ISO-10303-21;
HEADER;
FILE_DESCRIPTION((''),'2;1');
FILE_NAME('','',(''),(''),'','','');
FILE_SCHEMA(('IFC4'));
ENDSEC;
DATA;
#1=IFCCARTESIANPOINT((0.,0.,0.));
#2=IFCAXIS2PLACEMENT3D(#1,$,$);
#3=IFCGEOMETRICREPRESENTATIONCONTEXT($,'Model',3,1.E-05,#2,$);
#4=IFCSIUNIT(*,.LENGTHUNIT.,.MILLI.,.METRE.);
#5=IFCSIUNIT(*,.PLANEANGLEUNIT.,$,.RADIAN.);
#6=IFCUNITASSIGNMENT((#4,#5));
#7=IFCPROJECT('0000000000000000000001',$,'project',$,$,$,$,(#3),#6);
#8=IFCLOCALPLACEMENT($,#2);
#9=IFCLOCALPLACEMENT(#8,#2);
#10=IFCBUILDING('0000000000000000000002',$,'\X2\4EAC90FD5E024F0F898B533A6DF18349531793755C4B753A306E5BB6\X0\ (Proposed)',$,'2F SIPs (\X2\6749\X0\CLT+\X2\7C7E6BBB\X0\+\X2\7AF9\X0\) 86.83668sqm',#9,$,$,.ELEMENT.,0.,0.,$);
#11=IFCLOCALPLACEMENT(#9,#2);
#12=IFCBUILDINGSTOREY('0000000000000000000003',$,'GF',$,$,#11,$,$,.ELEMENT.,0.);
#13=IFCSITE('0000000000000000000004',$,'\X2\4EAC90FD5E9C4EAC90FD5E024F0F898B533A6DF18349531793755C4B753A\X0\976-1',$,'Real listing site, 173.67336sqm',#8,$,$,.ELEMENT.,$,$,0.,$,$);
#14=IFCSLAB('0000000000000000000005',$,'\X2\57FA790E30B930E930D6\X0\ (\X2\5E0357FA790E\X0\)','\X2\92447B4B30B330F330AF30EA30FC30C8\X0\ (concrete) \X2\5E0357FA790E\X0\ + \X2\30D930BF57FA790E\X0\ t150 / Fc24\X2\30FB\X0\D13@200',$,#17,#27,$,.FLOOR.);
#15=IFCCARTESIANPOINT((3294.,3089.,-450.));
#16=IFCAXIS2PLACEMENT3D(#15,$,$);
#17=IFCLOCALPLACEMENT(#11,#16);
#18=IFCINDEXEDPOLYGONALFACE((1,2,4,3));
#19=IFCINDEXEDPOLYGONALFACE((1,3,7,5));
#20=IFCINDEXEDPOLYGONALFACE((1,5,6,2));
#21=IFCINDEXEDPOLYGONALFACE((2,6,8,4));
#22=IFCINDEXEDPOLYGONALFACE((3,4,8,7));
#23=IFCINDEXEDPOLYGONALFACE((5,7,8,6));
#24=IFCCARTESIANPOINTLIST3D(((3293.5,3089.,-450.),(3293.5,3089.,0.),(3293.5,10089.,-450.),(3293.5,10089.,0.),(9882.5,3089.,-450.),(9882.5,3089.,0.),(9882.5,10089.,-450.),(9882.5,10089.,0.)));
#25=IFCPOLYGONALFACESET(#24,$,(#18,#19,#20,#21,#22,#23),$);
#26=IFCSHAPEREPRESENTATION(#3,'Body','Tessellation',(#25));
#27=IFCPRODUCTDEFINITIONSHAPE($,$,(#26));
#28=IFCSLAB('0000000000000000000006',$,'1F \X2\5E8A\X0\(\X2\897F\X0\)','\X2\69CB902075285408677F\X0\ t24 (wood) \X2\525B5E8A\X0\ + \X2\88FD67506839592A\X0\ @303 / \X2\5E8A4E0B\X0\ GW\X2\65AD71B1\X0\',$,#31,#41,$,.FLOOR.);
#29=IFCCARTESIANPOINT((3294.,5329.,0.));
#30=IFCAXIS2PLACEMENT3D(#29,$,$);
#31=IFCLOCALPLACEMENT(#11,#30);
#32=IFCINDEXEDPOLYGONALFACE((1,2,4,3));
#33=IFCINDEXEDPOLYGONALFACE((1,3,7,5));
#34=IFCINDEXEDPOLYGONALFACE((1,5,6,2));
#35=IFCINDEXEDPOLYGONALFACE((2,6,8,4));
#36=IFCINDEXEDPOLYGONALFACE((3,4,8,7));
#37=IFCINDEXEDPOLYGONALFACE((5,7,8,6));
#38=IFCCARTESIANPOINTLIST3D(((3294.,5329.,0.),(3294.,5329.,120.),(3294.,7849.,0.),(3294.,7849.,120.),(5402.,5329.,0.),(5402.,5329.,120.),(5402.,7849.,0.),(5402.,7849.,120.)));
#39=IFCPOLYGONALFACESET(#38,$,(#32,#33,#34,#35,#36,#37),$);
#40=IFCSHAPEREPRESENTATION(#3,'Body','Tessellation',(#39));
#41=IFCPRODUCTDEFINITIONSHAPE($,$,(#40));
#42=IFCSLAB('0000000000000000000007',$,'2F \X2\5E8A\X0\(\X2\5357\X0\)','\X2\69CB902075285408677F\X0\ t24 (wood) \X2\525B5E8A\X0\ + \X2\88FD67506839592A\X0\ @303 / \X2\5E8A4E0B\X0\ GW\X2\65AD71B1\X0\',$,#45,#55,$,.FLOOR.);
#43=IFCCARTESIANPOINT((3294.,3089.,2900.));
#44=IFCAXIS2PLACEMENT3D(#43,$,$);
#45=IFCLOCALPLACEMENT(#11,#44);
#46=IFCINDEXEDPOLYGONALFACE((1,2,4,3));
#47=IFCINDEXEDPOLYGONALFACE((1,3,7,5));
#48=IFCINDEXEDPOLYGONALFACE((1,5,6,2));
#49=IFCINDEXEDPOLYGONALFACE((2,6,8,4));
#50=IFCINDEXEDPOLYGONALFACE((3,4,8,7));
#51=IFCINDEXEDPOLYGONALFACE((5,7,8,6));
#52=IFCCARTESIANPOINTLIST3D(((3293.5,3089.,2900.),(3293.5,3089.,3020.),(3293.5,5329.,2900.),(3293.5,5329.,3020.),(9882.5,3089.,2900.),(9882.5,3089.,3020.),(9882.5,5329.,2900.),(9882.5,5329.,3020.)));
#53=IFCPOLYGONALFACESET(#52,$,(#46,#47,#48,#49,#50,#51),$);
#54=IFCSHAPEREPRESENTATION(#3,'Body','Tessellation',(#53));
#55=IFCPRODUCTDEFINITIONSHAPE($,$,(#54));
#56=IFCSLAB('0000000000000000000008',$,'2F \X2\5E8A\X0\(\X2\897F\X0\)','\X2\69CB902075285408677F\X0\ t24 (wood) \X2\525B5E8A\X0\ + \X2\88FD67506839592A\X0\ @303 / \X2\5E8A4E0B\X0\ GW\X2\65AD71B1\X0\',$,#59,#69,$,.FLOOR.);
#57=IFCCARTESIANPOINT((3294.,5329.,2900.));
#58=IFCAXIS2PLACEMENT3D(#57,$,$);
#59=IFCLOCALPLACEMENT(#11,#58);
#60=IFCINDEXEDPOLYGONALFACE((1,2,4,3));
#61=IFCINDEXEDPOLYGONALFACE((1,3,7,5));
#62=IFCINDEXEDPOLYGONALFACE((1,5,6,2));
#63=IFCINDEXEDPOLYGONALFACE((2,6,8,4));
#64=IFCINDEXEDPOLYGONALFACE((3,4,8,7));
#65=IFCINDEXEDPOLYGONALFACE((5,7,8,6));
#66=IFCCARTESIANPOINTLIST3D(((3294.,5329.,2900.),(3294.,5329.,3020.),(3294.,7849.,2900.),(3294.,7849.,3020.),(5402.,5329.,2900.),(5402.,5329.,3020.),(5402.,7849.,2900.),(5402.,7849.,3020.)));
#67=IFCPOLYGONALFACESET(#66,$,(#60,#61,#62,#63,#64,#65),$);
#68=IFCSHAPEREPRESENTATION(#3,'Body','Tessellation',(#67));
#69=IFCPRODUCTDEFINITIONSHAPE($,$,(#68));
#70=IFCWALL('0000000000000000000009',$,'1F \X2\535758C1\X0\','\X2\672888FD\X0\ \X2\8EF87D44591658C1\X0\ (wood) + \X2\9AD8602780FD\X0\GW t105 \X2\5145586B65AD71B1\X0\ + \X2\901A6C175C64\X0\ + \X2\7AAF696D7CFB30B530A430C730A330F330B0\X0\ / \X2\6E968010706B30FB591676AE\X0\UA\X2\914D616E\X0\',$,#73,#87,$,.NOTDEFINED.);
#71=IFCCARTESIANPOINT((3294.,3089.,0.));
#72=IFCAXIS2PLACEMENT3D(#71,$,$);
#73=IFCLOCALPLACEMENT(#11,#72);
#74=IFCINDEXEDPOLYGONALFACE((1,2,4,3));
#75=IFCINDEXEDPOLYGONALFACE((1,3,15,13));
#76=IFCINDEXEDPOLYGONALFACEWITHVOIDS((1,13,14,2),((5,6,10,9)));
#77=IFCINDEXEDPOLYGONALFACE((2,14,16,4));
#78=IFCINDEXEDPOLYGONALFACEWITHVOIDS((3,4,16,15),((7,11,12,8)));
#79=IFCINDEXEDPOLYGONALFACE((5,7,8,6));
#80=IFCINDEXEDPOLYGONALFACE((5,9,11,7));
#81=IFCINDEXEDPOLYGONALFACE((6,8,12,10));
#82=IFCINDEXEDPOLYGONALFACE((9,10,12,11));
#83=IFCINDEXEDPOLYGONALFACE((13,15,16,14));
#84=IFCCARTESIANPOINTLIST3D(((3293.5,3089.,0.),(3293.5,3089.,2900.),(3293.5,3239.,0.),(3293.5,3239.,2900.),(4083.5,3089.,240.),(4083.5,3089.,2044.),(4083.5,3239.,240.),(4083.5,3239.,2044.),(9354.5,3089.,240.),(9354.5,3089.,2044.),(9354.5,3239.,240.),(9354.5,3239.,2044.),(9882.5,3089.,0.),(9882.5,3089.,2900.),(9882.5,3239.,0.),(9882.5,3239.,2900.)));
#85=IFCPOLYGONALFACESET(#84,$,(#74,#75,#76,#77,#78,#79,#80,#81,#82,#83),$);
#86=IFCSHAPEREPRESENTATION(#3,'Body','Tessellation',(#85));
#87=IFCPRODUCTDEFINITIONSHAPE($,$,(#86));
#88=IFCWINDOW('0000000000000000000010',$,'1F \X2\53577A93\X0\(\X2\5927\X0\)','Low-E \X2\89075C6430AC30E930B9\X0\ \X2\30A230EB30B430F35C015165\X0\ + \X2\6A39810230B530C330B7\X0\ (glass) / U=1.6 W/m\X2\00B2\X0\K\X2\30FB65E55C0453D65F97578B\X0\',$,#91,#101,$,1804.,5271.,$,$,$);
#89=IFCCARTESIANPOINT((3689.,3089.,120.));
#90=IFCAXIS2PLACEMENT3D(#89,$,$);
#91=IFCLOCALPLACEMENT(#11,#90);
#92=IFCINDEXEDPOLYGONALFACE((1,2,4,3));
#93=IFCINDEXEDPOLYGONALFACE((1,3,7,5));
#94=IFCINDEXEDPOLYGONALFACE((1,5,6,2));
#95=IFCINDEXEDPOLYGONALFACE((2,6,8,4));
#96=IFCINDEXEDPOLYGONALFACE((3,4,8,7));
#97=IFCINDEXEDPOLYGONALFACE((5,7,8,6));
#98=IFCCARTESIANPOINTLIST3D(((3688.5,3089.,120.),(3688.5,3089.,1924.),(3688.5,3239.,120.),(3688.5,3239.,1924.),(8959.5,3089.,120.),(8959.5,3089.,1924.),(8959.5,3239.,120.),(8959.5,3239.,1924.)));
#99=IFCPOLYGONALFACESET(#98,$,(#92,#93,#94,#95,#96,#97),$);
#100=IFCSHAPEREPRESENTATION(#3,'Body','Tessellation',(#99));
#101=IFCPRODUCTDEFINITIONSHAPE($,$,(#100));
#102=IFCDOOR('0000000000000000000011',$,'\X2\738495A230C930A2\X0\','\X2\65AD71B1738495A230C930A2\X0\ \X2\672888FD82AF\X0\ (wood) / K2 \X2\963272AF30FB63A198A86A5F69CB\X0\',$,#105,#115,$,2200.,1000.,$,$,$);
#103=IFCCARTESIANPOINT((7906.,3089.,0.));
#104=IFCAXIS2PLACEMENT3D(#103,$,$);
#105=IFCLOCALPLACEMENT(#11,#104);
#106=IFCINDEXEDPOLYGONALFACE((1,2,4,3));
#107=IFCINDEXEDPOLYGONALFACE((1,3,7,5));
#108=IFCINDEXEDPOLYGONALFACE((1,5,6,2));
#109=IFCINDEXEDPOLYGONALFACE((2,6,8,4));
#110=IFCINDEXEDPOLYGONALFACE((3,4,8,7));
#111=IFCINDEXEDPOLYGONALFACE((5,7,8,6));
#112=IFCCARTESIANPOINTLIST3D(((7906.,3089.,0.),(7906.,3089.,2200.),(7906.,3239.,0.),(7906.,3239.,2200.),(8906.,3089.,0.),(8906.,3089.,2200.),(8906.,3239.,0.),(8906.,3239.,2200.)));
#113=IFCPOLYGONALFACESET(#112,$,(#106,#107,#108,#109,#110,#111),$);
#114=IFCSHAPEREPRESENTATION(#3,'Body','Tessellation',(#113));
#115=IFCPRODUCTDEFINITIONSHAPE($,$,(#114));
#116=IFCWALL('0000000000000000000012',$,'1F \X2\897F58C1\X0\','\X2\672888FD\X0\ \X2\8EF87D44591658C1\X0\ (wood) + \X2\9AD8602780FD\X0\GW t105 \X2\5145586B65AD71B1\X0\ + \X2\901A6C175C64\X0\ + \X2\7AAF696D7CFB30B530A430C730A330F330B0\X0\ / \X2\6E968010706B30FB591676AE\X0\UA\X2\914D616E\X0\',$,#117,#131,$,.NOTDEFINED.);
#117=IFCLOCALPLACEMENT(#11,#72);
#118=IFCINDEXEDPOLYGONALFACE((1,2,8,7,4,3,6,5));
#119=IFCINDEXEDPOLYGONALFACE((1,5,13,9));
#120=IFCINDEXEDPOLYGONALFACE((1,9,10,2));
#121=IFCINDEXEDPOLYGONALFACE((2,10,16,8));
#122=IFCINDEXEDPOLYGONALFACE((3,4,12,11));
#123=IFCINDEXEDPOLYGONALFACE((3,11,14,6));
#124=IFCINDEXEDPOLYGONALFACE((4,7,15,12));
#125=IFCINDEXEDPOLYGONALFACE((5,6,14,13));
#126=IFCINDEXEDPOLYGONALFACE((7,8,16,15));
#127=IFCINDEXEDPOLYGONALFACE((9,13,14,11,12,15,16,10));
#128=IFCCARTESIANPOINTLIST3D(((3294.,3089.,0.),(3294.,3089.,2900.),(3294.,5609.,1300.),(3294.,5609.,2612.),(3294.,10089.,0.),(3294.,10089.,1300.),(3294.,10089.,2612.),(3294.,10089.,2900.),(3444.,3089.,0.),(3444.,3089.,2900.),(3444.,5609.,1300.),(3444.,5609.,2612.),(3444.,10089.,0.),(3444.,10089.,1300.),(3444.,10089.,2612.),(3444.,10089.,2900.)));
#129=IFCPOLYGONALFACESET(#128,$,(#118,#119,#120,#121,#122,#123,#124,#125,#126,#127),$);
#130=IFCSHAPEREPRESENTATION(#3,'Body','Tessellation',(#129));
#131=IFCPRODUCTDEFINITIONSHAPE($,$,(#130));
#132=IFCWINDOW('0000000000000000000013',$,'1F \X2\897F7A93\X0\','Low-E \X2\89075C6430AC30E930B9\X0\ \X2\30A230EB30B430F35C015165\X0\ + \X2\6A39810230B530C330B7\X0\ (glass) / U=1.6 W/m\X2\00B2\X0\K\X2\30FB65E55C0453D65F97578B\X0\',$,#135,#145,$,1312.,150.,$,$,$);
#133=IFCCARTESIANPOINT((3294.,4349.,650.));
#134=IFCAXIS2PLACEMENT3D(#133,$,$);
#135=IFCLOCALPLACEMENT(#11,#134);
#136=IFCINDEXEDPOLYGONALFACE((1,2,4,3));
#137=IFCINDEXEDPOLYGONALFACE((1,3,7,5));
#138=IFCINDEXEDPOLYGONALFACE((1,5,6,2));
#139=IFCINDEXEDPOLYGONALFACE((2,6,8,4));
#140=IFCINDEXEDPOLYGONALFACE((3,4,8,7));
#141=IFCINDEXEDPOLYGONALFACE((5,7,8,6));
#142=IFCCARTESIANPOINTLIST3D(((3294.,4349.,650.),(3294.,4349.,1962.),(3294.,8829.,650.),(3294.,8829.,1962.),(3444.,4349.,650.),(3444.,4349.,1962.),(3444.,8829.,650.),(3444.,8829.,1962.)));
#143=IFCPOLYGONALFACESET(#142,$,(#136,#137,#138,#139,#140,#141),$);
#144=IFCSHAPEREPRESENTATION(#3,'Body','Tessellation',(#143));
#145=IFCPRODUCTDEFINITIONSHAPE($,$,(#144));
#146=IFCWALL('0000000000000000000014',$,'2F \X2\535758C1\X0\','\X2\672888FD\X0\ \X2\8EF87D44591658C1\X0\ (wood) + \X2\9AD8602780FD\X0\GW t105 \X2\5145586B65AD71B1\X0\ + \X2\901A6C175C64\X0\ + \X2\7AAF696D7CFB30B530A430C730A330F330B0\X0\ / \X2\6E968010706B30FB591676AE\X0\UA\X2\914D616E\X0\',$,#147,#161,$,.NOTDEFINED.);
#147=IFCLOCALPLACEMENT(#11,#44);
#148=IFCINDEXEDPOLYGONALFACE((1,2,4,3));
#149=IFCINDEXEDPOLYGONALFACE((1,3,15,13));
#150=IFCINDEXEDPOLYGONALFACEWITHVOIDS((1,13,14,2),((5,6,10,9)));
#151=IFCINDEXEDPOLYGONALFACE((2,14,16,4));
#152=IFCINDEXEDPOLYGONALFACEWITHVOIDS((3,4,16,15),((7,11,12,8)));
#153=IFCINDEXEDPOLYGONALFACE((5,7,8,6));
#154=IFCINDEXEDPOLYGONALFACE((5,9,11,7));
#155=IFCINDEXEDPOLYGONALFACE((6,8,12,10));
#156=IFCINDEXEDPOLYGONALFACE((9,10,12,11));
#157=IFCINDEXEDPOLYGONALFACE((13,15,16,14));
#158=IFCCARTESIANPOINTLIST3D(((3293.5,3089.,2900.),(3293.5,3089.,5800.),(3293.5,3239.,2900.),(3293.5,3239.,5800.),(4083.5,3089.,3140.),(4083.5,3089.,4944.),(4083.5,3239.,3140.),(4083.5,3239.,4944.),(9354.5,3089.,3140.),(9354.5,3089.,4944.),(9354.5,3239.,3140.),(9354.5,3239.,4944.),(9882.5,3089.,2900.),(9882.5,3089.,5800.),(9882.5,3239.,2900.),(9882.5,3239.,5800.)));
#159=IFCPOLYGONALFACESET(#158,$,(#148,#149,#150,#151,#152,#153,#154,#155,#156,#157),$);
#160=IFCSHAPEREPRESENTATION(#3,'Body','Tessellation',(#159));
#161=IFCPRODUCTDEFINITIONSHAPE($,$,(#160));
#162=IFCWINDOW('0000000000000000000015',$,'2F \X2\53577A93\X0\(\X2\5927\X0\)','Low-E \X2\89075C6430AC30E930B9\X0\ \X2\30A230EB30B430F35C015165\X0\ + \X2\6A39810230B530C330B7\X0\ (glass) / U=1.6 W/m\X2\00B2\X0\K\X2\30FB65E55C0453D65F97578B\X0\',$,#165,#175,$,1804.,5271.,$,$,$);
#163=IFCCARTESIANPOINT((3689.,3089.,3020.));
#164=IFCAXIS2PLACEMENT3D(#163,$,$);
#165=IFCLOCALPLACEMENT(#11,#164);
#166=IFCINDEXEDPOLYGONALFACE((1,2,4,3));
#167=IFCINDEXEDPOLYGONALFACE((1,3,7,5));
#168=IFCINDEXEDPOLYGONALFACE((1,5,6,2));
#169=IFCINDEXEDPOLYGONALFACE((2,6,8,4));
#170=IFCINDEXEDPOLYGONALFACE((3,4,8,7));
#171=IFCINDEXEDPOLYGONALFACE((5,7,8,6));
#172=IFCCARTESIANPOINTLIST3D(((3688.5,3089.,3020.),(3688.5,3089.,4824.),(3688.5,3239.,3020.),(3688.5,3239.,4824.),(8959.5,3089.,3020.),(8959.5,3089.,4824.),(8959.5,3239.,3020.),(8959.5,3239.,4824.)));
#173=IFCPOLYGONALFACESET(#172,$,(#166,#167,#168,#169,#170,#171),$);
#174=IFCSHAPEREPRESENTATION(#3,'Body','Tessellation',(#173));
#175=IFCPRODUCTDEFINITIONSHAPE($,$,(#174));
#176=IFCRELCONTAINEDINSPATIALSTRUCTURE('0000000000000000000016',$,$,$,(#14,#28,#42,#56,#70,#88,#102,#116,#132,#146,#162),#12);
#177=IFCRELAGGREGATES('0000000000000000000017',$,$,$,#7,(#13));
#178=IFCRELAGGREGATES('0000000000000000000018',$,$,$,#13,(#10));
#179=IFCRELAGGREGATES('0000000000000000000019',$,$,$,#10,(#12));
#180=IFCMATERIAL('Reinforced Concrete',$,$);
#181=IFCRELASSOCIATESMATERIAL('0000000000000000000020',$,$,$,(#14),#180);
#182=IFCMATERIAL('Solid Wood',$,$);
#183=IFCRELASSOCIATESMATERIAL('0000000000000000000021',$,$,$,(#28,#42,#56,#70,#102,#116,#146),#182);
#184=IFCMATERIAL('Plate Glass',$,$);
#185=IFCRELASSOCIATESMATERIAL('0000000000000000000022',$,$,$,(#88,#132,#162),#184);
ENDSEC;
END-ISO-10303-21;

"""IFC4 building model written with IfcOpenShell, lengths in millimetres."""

from ifc_helpers import new_model, si_unit, frame, frame_2d, origin, place, context, project, spatial, rectangle, extrude, material, element, fill, save


model = new_model("IFC4")

# Units and contexts
model_context = context("Model", 3, precision=1e-05, world=origin())
ifc_project = project(units=[si_unit("LENGTHUNIT", "METRE", prefix="MILLI"), si_unit("PLANEANGLEUNIT", "RADIAN")], contexts=[model_context])

# Site, building, storey
site_placement = place(None, origin())
site = spatial("IfcSite", under=ifc_project, at=site_placement, Name="京都府京都市伏見区深草北鍵屋町976-1", ObjectType="Real listing site, 173.67336sqm", CompositionType="ELEMENT", RefElevation=0.0)
building_placement = place(site_placement, origin())
building = spatial("IfcBuilding", under=site, at=building_placement, Name="京都市伏見区深草北鍵屋町の家 (Proposed)", ObjectType="2F SIPs (杉CLT+籾殻+竹) 86.83668sqm", CompositionType="ELEMENT", ElevationOfRefHeight=0.0, ElevationOfTerrain=0.0)
storey_placement = place(building_placement, origin())
storey = spatial("IfcBuildingStorey", under=building, at=storey_placement, Name="GF", CompositionType="ELEMENT", Elevation=0.0)

# Slabs
ifc_material_1 = material(Name="Reinforced Concrete")
slab_1_placement = place(storey_placement, frame((3294.0, 3089.0, -450.0)))
element("IfcSlab", 1, at=slab_1_placement, inside=storey, material=ifc_material_1, Name="基礎スラブ (布基礎)", Description="鉄筋コンクリート (concrete) 布基礎 + ベタ基礎 t150 / Fc24・D13@200", PredefinedType="FLOOR", context=model_context, shape_type="SweptSolid", body=[
    extrude(rectangle(XDim=6589.0, YDim=7000.0, at=frame_2d((3294.0, 3500.0))), frame((3294.0, 3089.0, -450.0)), (0.0, 0.0, 1.0), 450.0),
])
ifc_material_2 = material(Name="Solid Wood")
slab_2_placement = place(storey_placement, frame((3294.0, 5329.0, 0.0)))
element("IfcSlab", 2, at=slab_2_placement, inside=storey, material=ifc_material_2, Name="1F 床(西)", Description="構造用合板 t24 (wood) 剛床 + 製材根太 @303 / 床下 GW断熱", PredefinedType="FLOOR", context=model_context, shape_type="SweptSolid", body=[
    extrude(rectangle(XDim=2108.0, YDim=2520.0, at=frame_2d((1054.0, 1260.0))), frame((3294.0, 5329.0, 0.0)), (0.0, 0.0, 1.0), 120.0),
])
slab_3_placement = place(storey_placement, frame((3294.0, 3089.0, 2900.0)))
element("IfcSlab", 3, at=slab_3_placement, inside=storey, material=ifc_material_2, Name="2F 床(南)", Description="構造用合板 t24 (wood) 剛床 + 製材根太 @303 / 床下 GW断熱", PredefinedType="FLOOR", context=model_context, shape_type="SweptSolid", body=[
    extrude(rectangle(XDim=6589.0, YDim=2240.0, at=frame_2d((3294.0, 1120.0))), frame((3294.0, 3089.0, 2900.0)), (0.0, 0.0, 1.0), 120.0),
])
slab_4_placement = place(storey_placement, frame((3294.0, 5329.0, 2900.0)))
element("IfcSlab", 4, at=slab_4_placement, inside=storey, material=ifc_material_2, Name="2F 床(西)", Description="構造用合板 t24 (wood) 剛床 + 製材根太 @303 / 床下 GW断熱", PredefinedType="FLOOR", context=model_context, shape_type="SweptSolid", body=[
    extrude(rectangle(XDim=2108.0, YDim=2520.0, at=frame_2d((1054.0, 1260.0))), frame((3294.0, 5329.0, 2900.0)), (0.0, 0.0, 1.0), 120.0),
])

# Wall, openings, window, door
wall_1_placement = place(storey_placement, frame((3294.0, 3089.0, 0.0)))
wall_1 = element("IfcWall", 5, at=wall_1_placement, inside=storey, material=ifc_material_2, Name="1F 南壁", Description="木製 軸組外壁 (wood) + 高性能GW t105 充填断熱 + 通気層 + 窯業系サイディング / 準耐火・外皮UA配慮", PredefinedType="NOTDEFINED", context=model_context, shape_type="SweptSolid", body=[
    extrude(rectangle(XDim=6589.0, YDim=150.0, at=frame_2d((3294.0, 75.0))), frame((3294.0, 3089.0, 0.0)), (0.0, 0.0, 1.0), 2900.0),
])
opening_1_placement = place(storey_placement, frame((3689.0, 3089.0, 120.0)))
opening_1 = element("IfcOpeningElement", 6, at=opening_1_placement, cuts=wall_1, PredefinedType="NOTDEFINED", context=model_context, shape_type="SweptSolid", body=[
    extrude(rectangle(XDim=5271.0, YDim=150.0, at=frame_2d((2635.0, 75.0))), frame((3689.0, 3089.0, 120.0)), (0.0, 0.0, 1.0), 1804.0),
])
opening_2_placement = place(storey_placement, frame((7906.0, 3089.0, 0.0)))
opening_2 = element("IfcOpeningElement", 7, at=opening_2_placement, cuts=wall_1, PredefinedType="NOTDEFINED", context=model_context, shape_type="SweptSolid", body=[
    extrude(rectangle(XDim=1000.0, YDim=150.0, at=frame_2d((500.0, 75.0))), frame((7906.0, 3089.0, 0.0)), (0.0, 0.0, 1.0), 2200.0),
])
ifc_material_3 = material(Name="Plate Glass")
window_1_placement = place(storey_placement, frame((3689.0, 3089.0, 120.0)))
window_1 = element("IfcWindow", 8, at=window_1_placement, inside=storey, material=ifc_material_3, Name="1F 南窓(大)", Description="Low-E 複層ガラス アルゴン封入 + 樹脂サッシ (glass) / U=1.6 W/m²K・日射取得型", OverallHeight=1804.0, OverallWidth=5271.0, context=model_context, shape_type="SweptSolid", body=[
    extrude(rectangle(XDim=5271.0, YDim=150.0, at=frame_2d((2635.0, 75.0))), frame((3689.0, 3089.0, 120.0)), (0.0, 0.0, 1.0), 1804.0),
])
fill(opening_1, window_1)
door_placement = place(storey_placement, frame((7906.0, 3089.0, 0.0)))
door = element("IfcDoor", 9, at=door_placement, inside=storey, material=ifc_material_2, Name="玄関ドア", Description="断熱玄関ドア 木製芯 (wood) / K2 防犯・採風機構", OverallHeight=2200.0, OverallWidth=1000.0, context=model_context, shape_type="SweptSolid", body=[
    extrude(rectangle(XDim=1000.0, YDim=150.0, at=frame_2d((500.0, 75.0))), frame((7906.0, 3089.0, 0.0)), (0.0, 0.0, 1.0), 2200.0),
])
fill(opening_2, door)

# Walls, openings, windows
wall_2_placement = place(storey_placement, frame((3294.0, 3089.0, 0.0)))
wall_2 = element("IfcWall", 10, at=wall_2_placement, inside=storey, material=ifc_material_2, Name="1F 西壁", Description="木製 軸組外壁 (wood) + 高性能GW t105 充填断熱 + 通気層 + 窯業系サイディング / 準耐火・外皮UA配慮", PredefinedType="NOTDEFINED", context=model_context, shape_type="SweptSolid", body=[
    extrude(rectangle(XDim=150.0, YDim=7000.0, at=frame_2d((75.0, 3500.0))), frame((3294.0, 3089.0, 0.0)), (0.0, 0.0, 1.0), 2900.0),
])
opening_3_placement = place(storey_placement, frame((3294.0, 4349.0, 650.0)))
opening_3 = element("IfcOpeningElement", 11, at=opening_3_placement, cuts=wall_2, PredefinedType="NOTDEFINED", context=model_context, shape_type="SweptSolid", body=[
    extrude(rectangle(XDim=150.0, YDim=4480.0, at=frame_2d((75.0, 2240.0))), frame((3294.0, 4349.0, 650.0)), (0.0, 0.0, 1.0), 1312.0),
])
window_2_placement = place(storey_placement, frame((3294.0, 4349.0, 650.0)))
window_2 = element("IfcWindow", 12, at=window_2_placement, inside=storey, material=ifc_material_3, Name="1F 西窓", Description="Low-E 複層ガラス アルゴン封入 + 樹脂サッシ (glass) / U=1.6 W/m²K・日射取得型", OverallHeight=1312.0, OverallWidth=150.0, context=model_context, shape_type="SweptSolid", body=[
    extrude(rectangle(XDim=150.0, YDim=4480.0, at=frame_2d((75.0, 2240.0))), frame((3294.0, 4349.0, 650.0)), (0.0, 0.0, 1.0), 1312.0),
])
fill(opening_3, window_2)
wall_3_placement = place(storey_placement, frame((3294.0, 3089.0, 2900.0)))
wall_3 = element("IfcWall", 13, at=wall_3_placement, inside=storey, material=ifc_material_2, Name="2F 南壁", Description="木製 軸組外壁 (wood) + 高性能GW t105 充填断熱 + 通気層 + 窯業系サイディング / 準耐火・外皮UA配慮", PredefinedType="NOTDEFINED", context=model_context, shape_type="SweptSolid", body=[
    extrude(rectangle(XDim=6589.0, YDim=150.0, at=frame_2d((3294.0, 75.0))), frame((3294.0, 3089.0, 2900.0)), (0.0, 0.0, 1.0), 2900.0),
])
opening_4_placement = place(storey_placement, frame((3689.0, 3089.0, 3020.0)))
opening_4 = element("IfcOpeningElement", 14, at=opening_4_placement, cuts=wall_3, PredefinedType="NOTDEFINED", context=model_context, shape_type="SweptSolid", body=[
    extrude(rectangle(XDim=5271.0, YDim=150.0, at=frame_2d((2635.0, 75.0))), frame((3689.0, 3089.0, 3020.0)), (0.0, 0.0, 1.0), 1804.0),
])
window_3_placement = place(storey_placement, frame((3689.0, 3089.0, 3020.0)))
window_3 = element("IfcWindow", 15, at=window_3_placement, inside=storey, material=ifc_material_3, Name="2F 南窓(大)", Description="Low-E 複層ガラス アルゴン封入 + 樹脂サッシ (glass) / U=1.6 W/m²K・日射取得型", OverallHeight=1804.0, OverallWidth=5271.0, context=model_context, shape_type="SweptSolid", body=[
    extrude(rectangle(XDim=5271.0, YDim=150.0, at=frame_2d((2635.0, 75.0))), frame((3689.0, 3089.0, 3020.0)), (0.0, 0.0, 1.0), 1804.0),
])
fill(opening_4, window_3)

save(model, "model.ifc")
